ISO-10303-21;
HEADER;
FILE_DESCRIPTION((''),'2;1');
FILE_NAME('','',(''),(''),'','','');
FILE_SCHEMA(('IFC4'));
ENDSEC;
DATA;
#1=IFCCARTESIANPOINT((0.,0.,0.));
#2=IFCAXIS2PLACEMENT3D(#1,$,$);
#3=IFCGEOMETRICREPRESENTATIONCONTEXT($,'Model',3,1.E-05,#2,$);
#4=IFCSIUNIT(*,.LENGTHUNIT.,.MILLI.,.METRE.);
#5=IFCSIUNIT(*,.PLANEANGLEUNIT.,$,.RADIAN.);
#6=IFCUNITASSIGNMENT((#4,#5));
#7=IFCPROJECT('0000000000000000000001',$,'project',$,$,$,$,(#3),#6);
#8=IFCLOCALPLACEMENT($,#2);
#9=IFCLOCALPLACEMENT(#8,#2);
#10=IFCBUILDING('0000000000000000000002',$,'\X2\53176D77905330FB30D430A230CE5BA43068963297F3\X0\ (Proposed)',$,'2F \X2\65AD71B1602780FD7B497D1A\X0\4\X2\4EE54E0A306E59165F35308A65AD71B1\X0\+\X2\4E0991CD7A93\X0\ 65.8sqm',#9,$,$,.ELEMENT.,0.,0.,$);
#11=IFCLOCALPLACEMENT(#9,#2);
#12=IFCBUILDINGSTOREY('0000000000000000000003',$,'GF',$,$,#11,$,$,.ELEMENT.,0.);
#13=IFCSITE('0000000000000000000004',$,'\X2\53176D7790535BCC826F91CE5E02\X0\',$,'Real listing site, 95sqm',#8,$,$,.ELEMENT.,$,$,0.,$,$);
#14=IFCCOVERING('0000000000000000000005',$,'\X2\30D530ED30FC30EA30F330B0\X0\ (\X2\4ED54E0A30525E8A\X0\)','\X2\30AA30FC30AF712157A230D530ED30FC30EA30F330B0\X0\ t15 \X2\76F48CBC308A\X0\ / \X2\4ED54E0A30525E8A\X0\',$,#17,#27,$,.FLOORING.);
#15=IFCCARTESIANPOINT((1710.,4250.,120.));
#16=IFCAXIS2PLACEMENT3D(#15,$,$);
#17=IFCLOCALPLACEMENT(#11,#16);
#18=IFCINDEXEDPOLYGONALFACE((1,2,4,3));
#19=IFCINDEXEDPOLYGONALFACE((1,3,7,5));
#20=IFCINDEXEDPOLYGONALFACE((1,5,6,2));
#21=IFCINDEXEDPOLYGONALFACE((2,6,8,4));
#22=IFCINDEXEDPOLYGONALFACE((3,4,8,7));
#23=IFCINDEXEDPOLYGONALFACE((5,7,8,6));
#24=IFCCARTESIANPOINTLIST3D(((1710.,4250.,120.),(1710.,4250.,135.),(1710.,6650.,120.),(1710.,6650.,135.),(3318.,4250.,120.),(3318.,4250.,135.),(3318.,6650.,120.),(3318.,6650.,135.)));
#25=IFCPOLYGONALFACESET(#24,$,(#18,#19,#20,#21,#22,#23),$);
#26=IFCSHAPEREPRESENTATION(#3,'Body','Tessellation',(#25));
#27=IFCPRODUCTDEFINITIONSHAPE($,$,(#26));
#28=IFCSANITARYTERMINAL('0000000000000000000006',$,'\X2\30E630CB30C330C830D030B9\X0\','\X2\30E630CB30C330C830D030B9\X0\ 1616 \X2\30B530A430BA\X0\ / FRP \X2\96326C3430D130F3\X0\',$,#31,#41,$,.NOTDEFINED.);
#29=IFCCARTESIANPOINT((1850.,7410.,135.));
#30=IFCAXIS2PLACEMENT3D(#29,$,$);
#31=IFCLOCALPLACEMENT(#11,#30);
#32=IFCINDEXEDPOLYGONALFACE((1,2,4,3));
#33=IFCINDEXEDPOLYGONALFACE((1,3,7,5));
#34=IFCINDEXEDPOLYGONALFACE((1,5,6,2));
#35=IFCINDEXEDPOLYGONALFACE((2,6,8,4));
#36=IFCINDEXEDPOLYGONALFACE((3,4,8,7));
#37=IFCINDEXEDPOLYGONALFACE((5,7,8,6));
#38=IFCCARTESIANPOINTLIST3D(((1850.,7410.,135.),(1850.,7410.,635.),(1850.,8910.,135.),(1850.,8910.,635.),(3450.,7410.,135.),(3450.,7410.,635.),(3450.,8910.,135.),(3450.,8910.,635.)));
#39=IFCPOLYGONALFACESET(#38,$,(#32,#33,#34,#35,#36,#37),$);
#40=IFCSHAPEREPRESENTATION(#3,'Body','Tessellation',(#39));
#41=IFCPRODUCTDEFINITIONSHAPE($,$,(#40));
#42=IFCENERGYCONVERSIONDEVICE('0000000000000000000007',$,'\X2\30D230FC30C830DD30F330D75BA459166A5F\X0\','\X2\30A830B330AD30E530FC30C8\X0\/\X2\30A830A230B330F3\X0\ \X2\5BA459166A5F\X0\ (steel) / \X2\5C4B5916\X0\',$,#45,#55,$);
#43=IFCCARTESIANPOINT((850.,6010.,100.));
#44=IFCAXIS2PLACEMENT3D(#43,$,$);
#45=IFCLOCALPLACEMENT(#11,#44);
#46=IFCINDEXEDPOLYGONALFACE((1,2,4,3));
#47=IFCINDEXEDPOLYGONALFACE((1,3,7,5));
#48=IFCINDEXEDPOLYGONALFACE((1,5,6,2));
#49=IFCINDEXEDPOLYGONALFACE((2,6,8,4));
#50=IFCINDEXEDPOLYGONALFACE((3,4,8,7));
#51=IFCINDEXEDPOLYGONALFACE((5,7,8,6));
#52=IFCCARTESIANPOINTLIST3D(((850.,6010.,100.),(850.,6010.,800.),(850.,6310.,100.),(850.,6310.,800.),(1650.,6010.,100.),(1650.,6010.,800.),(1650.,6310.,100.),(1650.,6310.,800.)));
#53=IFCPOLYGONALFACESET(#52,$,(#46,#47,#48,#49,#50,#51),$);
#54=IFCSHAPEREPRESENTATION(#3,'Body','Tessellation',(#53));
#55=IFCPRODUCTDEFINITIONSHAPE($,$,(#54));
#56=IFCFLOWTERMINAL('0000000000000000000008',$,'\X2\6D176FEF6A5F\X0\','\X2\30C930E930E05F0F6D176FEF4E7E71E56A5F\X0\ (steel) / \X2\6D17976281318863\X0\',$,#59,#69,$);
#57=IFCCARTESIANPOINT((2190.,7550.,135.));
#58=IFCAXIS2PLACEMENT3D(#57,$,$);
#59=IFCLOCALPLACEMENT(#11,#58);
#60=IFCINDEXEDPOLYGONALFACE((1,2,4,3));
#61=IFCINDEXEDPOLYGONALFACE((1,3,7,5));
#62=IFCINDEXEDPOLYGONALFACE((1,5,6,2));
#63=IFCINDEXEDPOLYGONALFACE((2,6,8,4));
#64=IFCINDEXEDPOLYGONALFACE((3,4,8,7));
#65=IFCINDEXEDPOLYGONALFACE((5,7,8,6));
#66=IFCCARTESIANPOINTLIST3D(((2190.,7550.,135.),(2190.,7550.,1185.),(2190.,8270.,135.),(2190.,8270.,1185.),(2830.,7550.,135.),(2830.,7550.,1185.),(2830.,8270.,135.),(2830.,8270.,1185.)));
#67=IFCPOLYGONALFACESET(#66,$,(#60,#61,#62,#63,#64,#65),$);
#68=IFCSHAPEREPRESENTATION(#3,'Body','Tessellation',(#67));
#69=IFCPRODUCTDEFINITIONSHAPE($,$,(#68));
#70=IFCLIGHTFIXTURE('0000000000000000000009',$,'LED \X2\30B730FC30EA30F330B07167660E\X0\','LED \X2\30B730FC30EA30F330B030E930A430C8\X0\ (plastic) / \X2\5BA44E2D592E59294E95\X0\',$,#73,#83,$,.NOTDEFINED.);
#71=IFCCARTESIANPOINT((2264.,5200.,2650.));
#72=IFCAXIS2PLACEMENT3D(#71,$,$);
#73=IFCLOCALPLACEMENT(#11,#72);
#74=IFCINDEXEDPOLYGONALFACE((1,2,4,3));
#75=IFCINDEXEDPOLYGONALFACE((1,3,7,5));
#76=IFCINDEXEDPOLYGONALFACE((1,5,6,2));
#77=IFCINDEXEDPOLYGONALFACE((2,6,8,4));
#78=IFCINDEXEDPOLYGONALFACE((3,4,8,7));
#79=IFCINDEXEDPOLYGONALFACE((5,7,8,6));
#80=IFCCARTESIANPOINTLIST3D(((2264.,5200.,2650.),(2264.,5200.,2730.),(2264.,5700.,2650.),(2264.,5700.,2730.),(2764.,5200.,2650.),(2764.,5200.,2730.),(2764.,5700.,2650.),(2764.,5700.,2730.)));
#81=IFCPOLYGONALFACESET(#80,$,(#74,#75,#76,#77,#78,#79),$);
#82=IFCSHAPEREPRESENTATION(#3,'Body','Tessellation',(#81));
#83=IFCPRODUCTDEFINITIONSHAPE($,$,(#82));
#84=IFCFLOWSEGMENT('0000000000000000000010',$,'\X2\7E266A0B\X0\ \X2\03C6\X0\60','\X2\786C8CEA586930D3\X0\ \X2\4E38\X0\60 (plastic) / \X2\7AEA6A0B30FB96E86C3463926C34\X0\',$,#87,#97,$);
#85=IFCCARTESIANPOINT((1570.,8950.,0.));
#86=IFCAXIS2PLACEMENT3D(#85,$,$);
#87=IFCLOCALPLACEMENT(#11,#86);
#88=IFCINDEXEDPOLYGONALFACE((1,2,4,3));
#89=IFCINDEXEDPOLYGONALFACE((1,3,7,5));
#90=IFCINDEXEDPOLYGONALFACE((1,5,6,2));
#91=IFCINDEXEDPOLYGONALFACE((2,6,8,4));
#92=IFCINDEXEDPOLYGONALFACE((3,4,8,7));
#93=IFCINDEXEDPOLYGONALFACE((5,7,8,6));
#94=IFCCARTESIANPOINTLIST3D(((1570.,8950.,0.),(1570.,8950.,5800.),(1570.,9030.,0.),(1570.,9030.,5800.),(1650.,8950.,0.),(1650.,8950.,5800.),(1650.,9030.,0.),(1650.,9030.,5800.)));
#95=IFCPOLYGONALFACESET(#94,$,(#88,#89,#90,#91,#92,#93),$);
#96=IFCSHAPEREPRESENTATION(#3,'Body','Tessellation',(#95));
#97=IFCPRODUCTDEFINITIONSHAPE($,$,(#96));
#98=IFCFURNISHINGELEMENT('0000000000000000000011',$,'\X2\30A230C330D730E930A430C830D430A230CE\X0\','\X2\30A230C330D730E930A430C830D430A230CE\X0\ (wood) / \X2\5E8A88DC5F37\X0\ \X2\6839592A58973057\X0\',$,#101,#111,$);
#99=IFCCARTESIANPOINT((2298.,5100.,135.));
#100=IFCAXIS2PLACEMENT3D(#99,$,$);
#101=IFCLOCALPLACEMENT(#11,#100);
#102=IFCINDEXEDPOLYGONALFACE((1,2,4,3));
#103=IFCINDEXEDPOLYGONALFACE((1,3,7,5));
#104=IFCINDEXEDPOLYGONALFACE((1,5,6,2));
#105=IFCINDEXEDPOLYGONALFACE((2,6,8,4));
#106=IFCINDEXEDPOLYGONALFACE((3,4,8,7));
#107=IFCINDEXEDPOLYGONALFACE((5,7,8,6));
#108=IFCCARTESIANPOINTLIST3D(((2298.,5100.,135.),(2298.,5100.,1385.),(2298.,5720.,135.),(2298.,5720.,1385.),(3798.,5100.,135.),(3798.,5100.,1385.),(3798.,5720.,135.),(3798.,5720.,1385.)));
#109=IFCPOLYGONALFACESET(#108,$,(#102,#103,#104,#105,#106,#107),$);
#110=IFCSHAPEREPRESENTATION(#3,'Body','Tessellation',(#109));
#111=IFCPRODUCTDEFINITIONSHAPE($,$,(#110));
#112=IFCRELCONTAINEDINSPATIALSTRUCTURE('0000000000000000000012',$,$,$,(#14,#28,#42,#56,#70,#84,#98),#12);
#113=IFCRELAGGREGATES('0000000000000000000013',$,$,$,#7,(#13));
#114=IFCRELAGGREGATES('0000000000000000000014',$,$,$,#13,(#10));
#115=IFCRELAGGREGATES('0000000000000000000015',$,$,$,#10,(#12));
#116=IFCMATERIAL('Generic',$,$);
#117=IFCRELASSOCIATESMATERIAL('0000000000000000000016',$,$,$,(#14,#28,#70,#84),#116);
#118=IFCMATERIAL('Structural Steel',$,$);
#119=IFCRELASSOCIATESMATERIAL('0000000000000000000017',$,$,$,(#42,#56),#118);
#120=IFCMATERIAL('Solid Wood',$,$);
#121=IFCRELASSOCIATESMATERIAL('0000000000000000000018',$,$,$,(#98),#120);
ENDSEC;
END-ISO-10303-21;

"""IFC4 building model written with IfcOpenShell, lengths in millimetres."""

from ifc_helpers import new_model, si_unit, frame, frame_2d, origin, place, context, project, spatial, rectangle, extrude, material, element, save


model = new_model("IFC4")

# Units and contexts
model_context = context("Model", 3, precision=1e-05, world=origin())
ifc_project = project(units=[si_unit("LENGTHUNIT", "METRE", prefix="MILLI"), si_unit("PLANEANGLEUNIT", "RADIAN")], contexts=[model_context])

# Site, building, storey
site_placement = place(None, origin())
site = spatial("IfcSite", under=ifc_project, at=site_placement, Name="北海道富良野市", ObjectType="Real listing site, 95sqm", CompositionType="ELEMENT", RefElevation=0.0)
building_placement = place(site_placement, origin())
building = spatial("IfcBuilding", under=site, at=building_placement, Name="北海道・ピアノ室と防音 (Proposed)", ObjectType="2F 断熱性能等級4以上の外張り断熱+三重窓 65.8sqm", CompositionType="ELEMENT", ElevationOfRefHeight=0.0, ElevationOfTerrain=0.0)
storey_placement = place(building_placement, origin())
storey = spatial("IfcBuildingStorey", under=building, at=storey_placement, Name="GF", CompositionType="ELEMENT", Elevation=0.0)

# Shared definitions
ifc_material_1 = material(Name="Solid Wood")

# Covering
ifc_material_2 = material(Name="Generic")
covering_1_placement = place(storey_placement, frame((1710.0, 4250.0, 120.0)))
element("IfcCovering", 1, at=covering_1_placement, inside=storey, material=ifc_material_2, Name="フローリング (仕上げ床)", Description="オーク無垢フローリング t15 直貼り / 仕上げ床", PredefinedType="FLOORING", context=model_context, shape_type="SweptSolid", body=[
    extrude(rectangle(XDim=1608.0, YDim=2400.0, at=frame_2d((804.0, 1200.0))), frame((1710.0, 4250.0, 120.0)), (0.0, 0.0, 1.0), 15.0),
])

# Sanitary terminal
sanitary_terminal_placement = place(storey_placement, frame((1850.0, 7410.0, 135.0)))
element("IfcSanitaryTerminal", 2, at=sanitary_terminal_placement, inside=storey, material=ifc_material_2, Name="ユニットバス", Description="ユニットバス 1616 サイズ / FRP 防水パン", PredefinedType="NOTDEFINED", context=model_context, shape_type="SweptSolid", body=[
    extrude(rectangle(XDim=1600.0, YDim=1500.0, at=frame_2d((800.0, 750.0))), frame((1850.0, 7410.0, 135.0)), (0.0, 0.0, 1.0), 500.0),
])

# Shared definitions
ifc_material_3 = material(Name="Structural Steel")

# Energy conversion device
energy_conversion_device_placement = place(storey_placement, frame((850.0, 6010.0, 100.0)))
element("IfcEnergyConversionDevice", 3, at=energy_conversion_device_placement, inside=storey, material=ifc_material_3, Name="ヒートポンプ室外機", Description="エコキュート/エアコン 室外機 (steel) / 屋外", context=model_context, shape_type="SweptSolid", body=[
    extrude(rectangle(XDim=800.0, YDim=300.0, at=frame_2d((400.0, 150.0))), frame((850.0, 6010.0, 100.0)), (0.0, 0.0, 1.0), 700.0),
])

# Flow terminal
flow_terminal_placement = place(storey_placement, frame((2190.0, 7550.0, 135.0)))
element("IfcFlowTerminal", 4, at=flow_terminal_placement, inside=storey, material=ifc_material_3, Name="洗濯機", Description="ドラム式洗濯乾燥機 (steel) / 洗面脱衣", context=model_context, shape_type="SweptSolid", body=[
    extrude(rectangle(XDim=640.0, YDim=720.0, at=frame_2d((320.0, 360.0))), frame((2190.0, 7550.0, 135.0)), (0.0, 0.0, 1.0), 1050.0),
])

# Light fixture
light_fixture_placement = place(storey_placement, frame((2264.0, 5200.0, 2650.0)))
element("IfcLightFixture", 5, at=light_fixture_placement, inside=storey, material=ifc_material_2, Name="LED シーリング照明", Description="LED シーリングライト (plastic) / 室中央天井", PredefinedType="NOTDEFINED", context=model_context, shape_type="SweptSolid", body=[
    extrude(rectangle(XDim=500.0, YDim=500.0, at=frame_2d((250.0, 250.0))), frame((2264.0, 5200.0, 2650.0)), (0.0, 0.0, 1.0), 80.0),
])

# Flow segment
flow_segment_placement = place(storey_placement, frame((1570.0, 8950.0, 0.0)))
element("IfcFlowSegment", 6, at=flow_segment_placement, inside=storey, material=ifc_material_2, Name="縦樋 φ60", Description="硬質塩ビ 丸60 (plastic) / 竪樋・雨水排水", context=model_context, shape_type="SweptSolid", body=[
    extrude(rectangle(XDim=80.0, YDim=80.0, at=frame_2d((40.0, 40.0))), frame((1570.0, 8950.0, 0.0)), (0.0, 0.0, 1.0), 5800.0),
])

# Furnishing element
furnishing_placement = place(storey_placement, frame((2298.0, 5100.0, 135.0)))
element("IfcFurnishingElement", 7, at=furnishing_placement, inside=storey, material=ifc_material_1, Name="アップライトピアノ", Description="アップライトピアノ (wood) / 床補強 根太増し", context=model_context, shape_type="SweptSolid", body=[
    extrude(rectangle(XDim=1500.0, YDim=620.0, at=frame_2d((750.0, 310.0))), frame((2298.0, 5100.0, 135.0)), (0.0, 0.0, 1.0), 1250.0),
])

save(model, "model.ifc")
